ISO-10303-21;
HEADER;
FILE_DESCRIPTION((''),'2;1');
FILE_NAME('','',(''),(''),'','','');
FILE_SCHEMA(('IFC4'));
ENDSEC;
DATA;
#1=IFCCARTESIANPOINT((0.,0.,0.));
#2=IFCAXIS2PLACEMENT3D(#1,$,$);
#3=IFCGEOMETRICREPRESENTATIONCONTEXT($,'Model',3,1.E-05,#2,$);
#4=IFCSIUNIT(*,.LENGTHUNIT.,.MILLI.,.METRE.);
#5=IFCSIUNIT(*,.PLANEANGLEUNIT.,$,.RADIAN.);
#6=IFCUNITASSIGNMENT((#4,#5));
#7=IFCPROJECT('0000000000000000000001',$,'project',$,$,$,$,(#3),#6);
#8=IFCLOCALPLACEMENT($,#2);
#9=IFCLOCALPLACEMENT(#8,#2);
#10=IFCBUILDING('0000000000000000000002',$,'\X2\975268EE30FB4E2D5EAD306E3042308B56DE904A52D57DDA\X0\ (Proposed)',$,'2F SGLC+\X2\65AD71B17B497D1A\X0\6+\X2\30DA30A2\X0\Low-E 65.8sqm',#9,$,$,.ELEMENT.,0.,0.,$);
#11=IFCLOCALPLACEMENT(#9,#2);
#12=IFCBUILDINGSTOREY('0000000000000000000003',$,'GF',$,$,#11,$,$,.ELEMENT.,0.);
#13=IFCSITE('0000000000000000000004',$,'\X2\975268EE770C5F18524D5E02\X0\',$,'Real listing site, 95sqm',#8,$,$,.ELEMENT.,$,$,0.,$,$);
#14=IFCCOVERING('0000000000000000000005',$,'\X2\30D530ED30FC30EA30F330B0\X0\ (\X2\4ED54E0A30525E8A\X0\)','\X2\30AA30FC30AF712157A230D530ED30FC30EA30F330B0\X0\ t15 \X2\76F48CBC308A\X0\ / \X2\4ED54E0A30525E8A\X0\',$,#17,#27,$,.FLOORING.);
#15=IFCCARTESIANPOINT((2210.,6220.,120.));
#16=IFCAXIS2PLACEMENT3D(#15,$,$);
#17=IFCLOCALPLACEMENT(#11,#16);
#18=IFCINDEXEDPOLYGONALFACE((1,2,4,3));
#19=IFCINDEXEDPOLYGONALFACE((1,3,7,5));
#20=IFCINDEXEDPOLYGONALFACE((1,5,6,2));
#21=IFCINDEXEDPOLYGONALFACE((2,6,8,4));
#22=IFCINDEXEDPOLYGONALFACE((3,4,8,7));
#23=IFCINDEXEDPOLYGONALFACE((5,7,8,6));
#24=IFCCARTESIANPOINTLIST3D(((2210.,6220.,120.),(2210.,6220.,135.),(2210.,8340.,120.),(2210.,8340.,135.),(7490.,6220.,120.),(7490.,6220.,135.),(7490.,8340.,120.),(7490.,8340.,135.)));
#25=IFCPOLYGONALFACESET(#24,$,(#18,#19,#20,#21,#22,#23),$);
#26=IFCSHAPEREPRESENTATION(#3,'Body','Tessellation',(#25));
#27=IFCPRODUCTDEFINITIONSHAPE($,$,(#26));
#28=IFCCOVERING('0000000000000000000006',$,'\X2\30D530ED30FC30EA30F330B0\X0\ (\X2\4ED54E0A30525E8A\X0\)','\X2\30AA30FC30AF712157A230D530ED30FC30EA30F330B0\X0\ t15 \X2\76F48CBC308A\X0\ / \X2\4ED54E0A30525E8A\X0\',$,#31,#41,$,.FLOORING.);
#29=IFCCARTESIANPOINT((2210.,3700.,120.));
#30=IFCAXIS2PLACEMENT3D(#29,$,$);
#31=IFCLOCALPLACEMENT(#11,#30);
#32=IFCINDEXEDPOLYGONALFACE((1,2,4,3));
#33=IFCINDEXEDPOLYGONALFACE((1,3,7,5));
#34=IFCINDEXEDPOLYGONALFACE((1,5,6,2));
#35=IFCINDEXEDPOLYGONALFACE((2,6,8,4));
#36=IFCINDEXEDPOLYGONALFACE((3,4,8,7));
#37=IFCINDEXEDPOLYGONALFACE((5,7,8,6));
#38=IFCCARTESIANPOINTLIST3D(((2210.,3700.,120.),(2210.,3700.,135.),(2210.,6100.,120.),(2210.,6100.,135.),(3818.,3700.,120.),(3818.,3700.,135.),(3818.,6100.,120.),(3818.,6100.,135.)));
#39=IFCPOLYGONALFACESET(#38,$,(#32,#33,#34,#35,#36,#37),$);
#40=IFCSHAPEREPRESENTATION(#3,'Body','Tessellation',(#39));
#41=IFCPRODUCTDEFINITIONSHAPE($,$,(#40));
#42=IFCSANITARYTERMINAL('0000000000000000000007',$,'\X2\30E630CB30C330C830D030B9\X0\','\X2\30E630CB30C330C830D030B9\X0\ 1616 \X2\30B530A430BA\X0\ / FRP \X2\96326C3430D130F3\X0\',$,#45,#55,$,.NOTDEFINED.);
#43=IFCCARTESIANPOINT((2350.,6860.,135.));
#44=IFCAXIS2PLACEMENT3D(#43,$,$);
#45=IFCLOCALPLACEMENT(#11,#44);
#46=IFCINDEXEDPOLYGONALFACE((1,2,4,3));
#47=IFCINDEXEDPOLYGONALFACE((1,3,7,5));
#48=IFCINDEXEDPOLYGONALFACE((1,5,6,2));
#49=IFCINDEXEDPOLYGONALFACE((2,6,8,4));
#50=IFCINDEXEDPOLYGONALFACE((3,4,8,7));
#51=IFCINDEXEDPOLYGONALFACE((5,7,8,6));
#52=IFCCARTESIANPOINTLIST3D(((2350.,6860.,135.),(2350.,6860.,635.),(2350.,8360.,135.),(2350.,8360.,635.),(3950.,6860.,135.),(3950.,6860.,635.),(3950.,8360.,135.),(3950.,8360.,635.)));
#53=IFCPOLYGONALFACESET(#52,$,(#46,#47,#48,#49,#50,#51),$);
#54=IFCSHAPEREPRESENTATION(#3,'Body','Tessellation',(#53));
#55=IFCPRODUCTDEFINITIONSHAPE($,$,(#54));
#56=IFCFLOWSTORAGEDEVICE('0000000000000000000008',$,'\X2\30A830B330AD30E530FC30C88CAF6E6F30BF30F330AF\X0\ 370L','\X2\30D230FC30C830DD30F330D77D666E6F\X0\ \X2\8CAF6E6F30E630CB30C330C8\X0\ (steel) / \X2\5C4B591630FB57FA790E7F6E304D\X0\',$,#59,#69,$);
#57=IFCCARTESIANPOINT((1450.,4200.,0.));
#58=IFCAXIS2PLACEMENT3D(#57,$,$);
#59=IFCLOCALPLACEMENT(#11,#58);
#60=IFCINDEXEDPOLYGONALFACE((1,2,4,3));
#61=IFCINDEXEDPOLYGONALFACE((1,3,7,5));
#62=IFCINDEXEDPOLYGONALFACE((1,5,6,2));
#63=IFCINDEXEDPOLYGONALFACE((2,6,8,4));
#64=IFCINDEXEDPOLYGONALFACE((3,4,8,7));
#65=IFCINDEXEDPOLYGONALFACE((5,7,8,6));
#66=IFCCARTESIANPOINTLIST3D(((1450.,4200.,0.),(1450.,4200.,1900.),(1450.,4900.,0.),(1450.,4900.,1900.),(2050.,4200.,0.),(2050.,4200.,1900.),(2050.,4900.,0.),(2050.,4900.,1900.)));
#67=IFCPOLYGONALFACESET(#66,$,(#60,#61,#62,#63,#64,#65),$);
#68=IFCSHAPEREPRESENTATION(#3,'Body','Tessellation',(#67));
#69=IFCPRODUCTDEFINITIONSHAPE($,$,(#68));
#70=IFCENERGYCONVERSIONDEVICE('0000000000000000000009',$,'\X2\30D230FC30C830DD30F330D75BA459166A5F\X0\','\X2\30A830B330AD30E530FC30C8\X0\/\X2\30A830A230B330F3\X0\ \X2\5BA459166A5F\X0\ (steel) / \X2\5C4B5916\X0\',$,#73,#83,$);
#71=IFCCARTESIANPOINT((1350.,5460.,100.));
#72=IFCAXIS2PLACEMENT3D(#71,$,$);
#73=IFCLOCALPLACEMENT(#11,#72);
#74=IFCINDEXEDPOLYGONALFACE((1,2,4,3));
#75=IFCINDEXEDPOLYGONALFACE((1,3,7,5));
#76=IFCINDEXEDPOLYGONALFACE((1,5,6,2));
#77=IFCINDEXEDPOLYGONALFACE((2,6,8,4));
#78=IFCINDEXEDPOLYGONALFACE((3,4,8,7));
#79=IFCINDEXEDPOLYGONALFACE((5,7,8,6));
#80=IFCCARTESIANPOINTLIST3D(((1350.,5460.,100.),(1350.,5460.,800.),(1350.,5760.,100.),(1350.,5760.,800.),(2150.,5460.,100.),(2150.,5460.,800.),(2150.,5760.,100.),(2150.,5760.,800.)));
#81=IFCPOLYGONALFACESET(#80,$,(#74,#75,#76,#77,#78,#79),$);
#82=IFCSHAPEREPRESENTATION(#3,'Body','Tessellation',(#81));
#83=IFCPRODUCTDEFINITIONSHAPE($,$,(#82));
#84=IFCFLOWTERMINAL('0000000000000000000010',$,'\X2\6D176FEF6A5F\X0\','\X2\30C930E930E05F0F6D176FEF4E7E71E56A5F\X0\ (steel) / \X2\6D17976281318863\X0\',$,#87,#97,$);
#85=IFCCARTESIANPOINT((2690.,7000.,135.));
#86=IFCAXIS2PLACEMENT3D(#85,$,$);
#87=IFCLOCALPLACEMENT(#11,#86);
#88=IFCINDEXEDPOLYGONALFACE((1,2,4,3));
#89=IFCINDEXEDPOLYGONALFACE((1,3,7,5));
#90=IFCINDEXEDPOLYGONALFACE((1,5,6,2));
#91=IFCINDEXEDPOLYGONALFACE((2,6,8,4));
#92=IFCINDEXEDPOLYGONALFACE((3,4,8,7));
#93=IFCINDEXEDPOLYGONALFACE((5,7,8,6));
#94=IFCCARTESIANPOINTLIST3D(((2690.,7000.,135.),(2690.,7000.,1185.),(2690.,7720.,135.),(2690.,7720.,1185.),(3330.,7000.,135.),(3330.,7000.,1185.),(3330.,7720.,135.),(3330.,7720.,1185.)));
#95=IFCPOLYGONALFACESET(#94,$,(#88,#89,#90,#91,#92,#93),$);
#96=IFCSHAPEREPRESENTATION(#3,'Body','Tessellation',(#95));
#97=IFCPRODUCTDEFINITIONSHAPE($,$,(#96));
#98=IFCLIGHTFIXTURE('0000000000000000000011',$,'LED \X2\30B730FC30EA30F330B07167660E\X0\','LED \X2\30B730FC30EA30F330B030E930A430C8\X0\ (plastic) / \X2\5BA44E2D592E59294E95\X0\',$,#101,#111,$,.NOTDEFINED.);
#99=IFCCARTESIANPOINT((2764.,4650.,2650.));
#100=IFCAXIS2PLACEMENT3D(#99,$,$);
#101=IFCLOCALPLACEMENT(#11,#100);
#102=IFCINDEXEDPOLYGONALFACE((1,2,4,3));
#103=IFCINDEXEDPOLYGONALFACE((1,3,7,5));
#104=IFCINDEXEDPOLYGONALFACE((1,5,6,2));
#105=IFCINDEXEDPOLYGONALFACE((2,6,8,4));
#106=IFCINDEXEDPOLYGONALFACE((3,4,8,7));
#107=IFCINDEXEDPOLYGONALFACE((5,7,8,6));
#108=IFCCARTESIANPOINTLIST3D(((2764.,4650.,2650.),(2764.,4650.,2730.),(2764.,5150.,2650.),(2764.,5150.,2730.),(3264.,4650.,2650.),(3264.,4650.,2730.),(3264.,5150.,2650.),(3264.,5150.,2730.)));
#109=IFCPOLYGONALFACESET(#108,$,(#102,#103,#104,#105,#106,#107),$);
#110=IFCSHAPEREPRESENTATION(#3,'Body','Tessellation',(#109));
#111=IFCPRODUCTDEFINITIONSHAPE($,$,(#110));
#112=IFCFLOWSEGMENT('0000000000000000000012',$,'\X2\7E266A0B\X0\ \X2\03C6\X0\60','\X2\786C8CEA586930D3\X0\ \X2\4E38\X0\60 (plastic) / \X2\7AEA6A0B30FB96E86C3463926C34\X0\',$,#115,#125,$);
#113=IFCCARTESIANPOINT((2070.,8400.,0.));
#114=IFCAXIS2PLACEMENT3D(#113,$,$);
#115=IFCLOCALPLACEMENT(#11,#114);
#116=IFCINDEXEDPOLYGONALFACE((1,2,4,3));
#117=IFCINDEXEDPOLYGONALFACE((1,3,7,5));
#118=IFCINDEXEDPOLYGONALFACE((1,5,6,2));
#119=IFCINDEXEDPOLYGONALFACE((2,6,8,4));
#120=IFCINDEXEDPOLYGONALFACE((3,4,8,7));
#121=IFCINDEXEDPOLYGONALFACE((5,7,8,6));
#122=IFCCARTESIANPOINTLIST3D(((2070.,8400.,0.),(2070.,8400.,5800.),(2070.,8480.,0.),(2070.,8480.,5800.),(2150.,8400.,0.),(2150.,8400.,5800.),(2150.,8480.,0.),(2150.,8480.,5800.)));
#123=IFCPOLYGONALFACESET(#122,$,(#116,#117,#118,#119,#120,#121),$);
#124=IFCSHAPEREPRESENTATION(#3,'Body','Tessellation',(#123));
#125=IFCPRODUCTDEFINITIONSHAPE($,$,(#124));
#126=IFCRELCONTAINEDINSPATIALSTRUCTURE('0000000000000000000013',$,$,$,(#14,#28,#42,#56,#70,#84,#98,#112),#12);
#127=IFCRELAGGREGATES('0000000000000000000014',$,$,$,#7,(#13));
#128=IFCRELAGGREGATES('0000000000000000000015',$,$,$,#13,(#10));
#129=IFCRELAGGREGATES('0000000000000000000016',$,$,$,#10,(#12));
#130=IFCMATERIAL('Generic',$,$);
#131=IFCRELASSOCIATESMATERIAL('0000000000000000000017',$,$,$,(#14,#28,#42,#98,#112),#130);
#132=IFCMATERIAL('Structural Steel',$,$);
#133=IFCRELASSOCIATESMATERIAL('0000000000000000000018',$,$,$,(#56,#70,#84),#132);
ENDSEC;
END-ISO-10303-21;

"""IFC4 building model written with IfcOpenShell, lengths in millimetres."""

from ifc_helpers import new_model, si_unit, frame, frame_2d, origin, place, context, project, spatial, rectangle, extrude, material, element, save


model = new_model("IFC4")

# Units and contexts
model_context = context("Model", 3, precision=1e-05, world=origin())
ifc_project = project(units=[si_unit("LENGTHUNIT", "METRE", prefix="MILLI"), si_unit("PLANEANGLEUNIT", "RADIAN")], contexts=[model_context])

# Site, building, storey
site_placement = place(None, origin())
site = spatial("IfcSite", under=ifc_project, at=site_placement, Name="青森県弘前市", ObjectType="Real listing site, 95sqm", CompositionType="ELEMENT", RefElevation=0.0)
building_placement = place(site_placement, origin())
building = spatial("IfcBuilding", under=site, at=building_placement, Name="青森・中庭のある回遊動線 (Proposed)", ObjectType="2F SGLC+断熱等級6+ペアLow-E 65.8sqm", CompositionType="ELEMENT", ElevationOfRefHeight=0.0, ElevationOfTerrain=0.0)
storey_placement = place(building_placement, origin())
storey = spatial("IfcBuildingStorey", under=building, at=storey_placement, Name="GF", CompositionType="ELEMENT", Elevation=0.0)

# Coverings
ifc_material_1 = material(Name="Generic")
covering_1_placement = place(storey_placement, frame((2210.0, 6220.0, 120.0)))
element("IfcCovering", 1, at=covering_1_placement, inside=storey, material=ifc_material_1, Name="フローリング (仕上げ床)", Description="オーク無垢フローリング t15 直貼り / 仕上げ床", PredefinedType="FLOORING", context=model_context, shape_type="SweptSolid", body=[
    extrude(rectangle(XDim=5280.0, YDim=2120.0, at=frame_2d((2640.0, 1060.0))), frame((2210.0, 6220.0, 120.0)), (0.0, 0.0, 1.0), 15.0),
])
covering_2_placement = place(storey_placement, frame((2210.0, 3700.0, 120.0)))
element("IfcCovering", 2, at=covering_2_placement, inside=storey, material=ifc_material_1, Name="フローリング (仕上げ床)", Description="オーク無垢フローリング t15 直貼り / 仕上げ床", PredefinedType="FLOORING", context=model_context, shape_type="SweptSolid", body=[
    extrude(rectangle(XDim=1608.0, YDim=2400.0, at=frame_2d((804.0, 1200.0))), frame((2210.0, 3700.0, 120.0)), (0.0, 0.0, 1.0), 15.0),
])

# Sanitary terminal
sanitary_terminal_placement = place(storey_placement, frame((2350.0, 6860.0, 135.0)))
element("IfcSanitaryTerminal", 3, at=sanitary_terminal_placement, inside=storey, material=ifc_material_1, Name="ユニットバス", Description="ユニットバス 1616 サイズ / FRP 防水パン", PredefinedType="NOTDEFINED", context=model_context, shape_type="SweptSolid", body=[
    extrude(rectangle(XDim=1600.0, YDim=1500.0, at=frame_2d((800.0, 750.0))), frame((2350.0, 6860.0, 135.0)), (0.0, 0.0, 1.0), 500.0),
])

# Flow storage device
ifc_material_2 = material(Name="Structural Steel")
flow_storage_device_placement = place(storey_placement, frame((1450.0, 4200.0, 0.0)))
element("IfcFlowStorageDevice", 4, at=flow_storage_device_placement, inside=storey, material=ifc_material_2, Name="エコキュート貯湯タンク 370L", Description="ヒートポンプ給湯 貯湯ユニット (steel) / 屋外・基礎置き", context=model_context, shape_type="SweptSolid", body=[
    extrude(rectangle(XDim=600.0, YDim=700.0, at=frame_2d((300.0, 350.0))), frame((1450.0, 4200.0, 0.0)), (0.0, 0.0, 1.0), 1900.0),
])

# Energy conversion device
energy_conversion_device_placement = place(storey_placement, frame((1350.0, 5460.0, 100.0)))
element("IfcEnergyConversionDevice", 5, at=energy_conversion_device_placement, inside=storey, material=ifc_material_2, Name="ヒートポンプ室外機", Description="エコキュート/エアコン 室外機 (steel) / 屋外", context=model_context, shape_type="SweptSolid", body=[
    extrude(rectangle(XDim=800.0, YDim=300.0, at=frame_2d((400.0, 150.0))), frame((1350.0, 5460.0, 100.0)), (0.0, 0.0, 1.0), 700.0),
])

# Flow terminal
flow_terminal_placement = place(storey_placement, frame((2690.0, 7000.0, 135.0)))
element("IfcFlowTerminal", 6, at=flow_terminal_placement, inside=storey, material=ifc_material_2, Name="洗濯機", Description="ドラム式洗濯乾燥機 (steel) / 洗面脱衣", context=model_context, shape_type="SweptSolid", body=[
    extrude(rectangle(XDim=640.0, YDim=720.0, at=frame_2d((320.0, 360.0))), frame((2690.0, 7000.0, 135.0)), (0.0, 0.0, 1.0), 1050.0),
])

# Light fixture
light_fixture_placement = place(storey_placement, frame((2764.0, 4650.0, 2650.0)))
element("IfcLightFixture", 7, at=light_fixture_placement, inside=storey, material=ifc_material_1, Name="LED シーリング照明", Description="LED シーリングライト (plastic) / 室中央天井", PredefinedType="NOTDEFINED", context=model_context, shape_type="SweptSolid", body=[
    extrude(rectangle(XDim=500.0, YDim=500.0, at=frame_2d((250.0, 250.0))), frame((2764.0, 4650.0, 2650.0)), (0.0, 0.0, 1.0), 80.0),
])

# Flow segment
flow_segment_placement = place(storey_placement, frame((2070.0, 8400.0, 0.0)))
element("IfcFlowSegment", 8, at=flow_segment_placement, inside=storey, material=ifc_material_1, Name="縦樋 φ60", Description="硬質塩ビ 丸60 (plastic) / 竪樋・雨水排水", context=model_context, shape_type="SweptSolid", body=[
    extrude(rectangle(XDim=80.0, YDim=80.0, at=frame_2d((40.0, 40.0))), frame((2070.0, 8400.0, 0.0)), (0.0, 0.0, 1.0), 5800.0),
])

save(model, "model.ifc")
